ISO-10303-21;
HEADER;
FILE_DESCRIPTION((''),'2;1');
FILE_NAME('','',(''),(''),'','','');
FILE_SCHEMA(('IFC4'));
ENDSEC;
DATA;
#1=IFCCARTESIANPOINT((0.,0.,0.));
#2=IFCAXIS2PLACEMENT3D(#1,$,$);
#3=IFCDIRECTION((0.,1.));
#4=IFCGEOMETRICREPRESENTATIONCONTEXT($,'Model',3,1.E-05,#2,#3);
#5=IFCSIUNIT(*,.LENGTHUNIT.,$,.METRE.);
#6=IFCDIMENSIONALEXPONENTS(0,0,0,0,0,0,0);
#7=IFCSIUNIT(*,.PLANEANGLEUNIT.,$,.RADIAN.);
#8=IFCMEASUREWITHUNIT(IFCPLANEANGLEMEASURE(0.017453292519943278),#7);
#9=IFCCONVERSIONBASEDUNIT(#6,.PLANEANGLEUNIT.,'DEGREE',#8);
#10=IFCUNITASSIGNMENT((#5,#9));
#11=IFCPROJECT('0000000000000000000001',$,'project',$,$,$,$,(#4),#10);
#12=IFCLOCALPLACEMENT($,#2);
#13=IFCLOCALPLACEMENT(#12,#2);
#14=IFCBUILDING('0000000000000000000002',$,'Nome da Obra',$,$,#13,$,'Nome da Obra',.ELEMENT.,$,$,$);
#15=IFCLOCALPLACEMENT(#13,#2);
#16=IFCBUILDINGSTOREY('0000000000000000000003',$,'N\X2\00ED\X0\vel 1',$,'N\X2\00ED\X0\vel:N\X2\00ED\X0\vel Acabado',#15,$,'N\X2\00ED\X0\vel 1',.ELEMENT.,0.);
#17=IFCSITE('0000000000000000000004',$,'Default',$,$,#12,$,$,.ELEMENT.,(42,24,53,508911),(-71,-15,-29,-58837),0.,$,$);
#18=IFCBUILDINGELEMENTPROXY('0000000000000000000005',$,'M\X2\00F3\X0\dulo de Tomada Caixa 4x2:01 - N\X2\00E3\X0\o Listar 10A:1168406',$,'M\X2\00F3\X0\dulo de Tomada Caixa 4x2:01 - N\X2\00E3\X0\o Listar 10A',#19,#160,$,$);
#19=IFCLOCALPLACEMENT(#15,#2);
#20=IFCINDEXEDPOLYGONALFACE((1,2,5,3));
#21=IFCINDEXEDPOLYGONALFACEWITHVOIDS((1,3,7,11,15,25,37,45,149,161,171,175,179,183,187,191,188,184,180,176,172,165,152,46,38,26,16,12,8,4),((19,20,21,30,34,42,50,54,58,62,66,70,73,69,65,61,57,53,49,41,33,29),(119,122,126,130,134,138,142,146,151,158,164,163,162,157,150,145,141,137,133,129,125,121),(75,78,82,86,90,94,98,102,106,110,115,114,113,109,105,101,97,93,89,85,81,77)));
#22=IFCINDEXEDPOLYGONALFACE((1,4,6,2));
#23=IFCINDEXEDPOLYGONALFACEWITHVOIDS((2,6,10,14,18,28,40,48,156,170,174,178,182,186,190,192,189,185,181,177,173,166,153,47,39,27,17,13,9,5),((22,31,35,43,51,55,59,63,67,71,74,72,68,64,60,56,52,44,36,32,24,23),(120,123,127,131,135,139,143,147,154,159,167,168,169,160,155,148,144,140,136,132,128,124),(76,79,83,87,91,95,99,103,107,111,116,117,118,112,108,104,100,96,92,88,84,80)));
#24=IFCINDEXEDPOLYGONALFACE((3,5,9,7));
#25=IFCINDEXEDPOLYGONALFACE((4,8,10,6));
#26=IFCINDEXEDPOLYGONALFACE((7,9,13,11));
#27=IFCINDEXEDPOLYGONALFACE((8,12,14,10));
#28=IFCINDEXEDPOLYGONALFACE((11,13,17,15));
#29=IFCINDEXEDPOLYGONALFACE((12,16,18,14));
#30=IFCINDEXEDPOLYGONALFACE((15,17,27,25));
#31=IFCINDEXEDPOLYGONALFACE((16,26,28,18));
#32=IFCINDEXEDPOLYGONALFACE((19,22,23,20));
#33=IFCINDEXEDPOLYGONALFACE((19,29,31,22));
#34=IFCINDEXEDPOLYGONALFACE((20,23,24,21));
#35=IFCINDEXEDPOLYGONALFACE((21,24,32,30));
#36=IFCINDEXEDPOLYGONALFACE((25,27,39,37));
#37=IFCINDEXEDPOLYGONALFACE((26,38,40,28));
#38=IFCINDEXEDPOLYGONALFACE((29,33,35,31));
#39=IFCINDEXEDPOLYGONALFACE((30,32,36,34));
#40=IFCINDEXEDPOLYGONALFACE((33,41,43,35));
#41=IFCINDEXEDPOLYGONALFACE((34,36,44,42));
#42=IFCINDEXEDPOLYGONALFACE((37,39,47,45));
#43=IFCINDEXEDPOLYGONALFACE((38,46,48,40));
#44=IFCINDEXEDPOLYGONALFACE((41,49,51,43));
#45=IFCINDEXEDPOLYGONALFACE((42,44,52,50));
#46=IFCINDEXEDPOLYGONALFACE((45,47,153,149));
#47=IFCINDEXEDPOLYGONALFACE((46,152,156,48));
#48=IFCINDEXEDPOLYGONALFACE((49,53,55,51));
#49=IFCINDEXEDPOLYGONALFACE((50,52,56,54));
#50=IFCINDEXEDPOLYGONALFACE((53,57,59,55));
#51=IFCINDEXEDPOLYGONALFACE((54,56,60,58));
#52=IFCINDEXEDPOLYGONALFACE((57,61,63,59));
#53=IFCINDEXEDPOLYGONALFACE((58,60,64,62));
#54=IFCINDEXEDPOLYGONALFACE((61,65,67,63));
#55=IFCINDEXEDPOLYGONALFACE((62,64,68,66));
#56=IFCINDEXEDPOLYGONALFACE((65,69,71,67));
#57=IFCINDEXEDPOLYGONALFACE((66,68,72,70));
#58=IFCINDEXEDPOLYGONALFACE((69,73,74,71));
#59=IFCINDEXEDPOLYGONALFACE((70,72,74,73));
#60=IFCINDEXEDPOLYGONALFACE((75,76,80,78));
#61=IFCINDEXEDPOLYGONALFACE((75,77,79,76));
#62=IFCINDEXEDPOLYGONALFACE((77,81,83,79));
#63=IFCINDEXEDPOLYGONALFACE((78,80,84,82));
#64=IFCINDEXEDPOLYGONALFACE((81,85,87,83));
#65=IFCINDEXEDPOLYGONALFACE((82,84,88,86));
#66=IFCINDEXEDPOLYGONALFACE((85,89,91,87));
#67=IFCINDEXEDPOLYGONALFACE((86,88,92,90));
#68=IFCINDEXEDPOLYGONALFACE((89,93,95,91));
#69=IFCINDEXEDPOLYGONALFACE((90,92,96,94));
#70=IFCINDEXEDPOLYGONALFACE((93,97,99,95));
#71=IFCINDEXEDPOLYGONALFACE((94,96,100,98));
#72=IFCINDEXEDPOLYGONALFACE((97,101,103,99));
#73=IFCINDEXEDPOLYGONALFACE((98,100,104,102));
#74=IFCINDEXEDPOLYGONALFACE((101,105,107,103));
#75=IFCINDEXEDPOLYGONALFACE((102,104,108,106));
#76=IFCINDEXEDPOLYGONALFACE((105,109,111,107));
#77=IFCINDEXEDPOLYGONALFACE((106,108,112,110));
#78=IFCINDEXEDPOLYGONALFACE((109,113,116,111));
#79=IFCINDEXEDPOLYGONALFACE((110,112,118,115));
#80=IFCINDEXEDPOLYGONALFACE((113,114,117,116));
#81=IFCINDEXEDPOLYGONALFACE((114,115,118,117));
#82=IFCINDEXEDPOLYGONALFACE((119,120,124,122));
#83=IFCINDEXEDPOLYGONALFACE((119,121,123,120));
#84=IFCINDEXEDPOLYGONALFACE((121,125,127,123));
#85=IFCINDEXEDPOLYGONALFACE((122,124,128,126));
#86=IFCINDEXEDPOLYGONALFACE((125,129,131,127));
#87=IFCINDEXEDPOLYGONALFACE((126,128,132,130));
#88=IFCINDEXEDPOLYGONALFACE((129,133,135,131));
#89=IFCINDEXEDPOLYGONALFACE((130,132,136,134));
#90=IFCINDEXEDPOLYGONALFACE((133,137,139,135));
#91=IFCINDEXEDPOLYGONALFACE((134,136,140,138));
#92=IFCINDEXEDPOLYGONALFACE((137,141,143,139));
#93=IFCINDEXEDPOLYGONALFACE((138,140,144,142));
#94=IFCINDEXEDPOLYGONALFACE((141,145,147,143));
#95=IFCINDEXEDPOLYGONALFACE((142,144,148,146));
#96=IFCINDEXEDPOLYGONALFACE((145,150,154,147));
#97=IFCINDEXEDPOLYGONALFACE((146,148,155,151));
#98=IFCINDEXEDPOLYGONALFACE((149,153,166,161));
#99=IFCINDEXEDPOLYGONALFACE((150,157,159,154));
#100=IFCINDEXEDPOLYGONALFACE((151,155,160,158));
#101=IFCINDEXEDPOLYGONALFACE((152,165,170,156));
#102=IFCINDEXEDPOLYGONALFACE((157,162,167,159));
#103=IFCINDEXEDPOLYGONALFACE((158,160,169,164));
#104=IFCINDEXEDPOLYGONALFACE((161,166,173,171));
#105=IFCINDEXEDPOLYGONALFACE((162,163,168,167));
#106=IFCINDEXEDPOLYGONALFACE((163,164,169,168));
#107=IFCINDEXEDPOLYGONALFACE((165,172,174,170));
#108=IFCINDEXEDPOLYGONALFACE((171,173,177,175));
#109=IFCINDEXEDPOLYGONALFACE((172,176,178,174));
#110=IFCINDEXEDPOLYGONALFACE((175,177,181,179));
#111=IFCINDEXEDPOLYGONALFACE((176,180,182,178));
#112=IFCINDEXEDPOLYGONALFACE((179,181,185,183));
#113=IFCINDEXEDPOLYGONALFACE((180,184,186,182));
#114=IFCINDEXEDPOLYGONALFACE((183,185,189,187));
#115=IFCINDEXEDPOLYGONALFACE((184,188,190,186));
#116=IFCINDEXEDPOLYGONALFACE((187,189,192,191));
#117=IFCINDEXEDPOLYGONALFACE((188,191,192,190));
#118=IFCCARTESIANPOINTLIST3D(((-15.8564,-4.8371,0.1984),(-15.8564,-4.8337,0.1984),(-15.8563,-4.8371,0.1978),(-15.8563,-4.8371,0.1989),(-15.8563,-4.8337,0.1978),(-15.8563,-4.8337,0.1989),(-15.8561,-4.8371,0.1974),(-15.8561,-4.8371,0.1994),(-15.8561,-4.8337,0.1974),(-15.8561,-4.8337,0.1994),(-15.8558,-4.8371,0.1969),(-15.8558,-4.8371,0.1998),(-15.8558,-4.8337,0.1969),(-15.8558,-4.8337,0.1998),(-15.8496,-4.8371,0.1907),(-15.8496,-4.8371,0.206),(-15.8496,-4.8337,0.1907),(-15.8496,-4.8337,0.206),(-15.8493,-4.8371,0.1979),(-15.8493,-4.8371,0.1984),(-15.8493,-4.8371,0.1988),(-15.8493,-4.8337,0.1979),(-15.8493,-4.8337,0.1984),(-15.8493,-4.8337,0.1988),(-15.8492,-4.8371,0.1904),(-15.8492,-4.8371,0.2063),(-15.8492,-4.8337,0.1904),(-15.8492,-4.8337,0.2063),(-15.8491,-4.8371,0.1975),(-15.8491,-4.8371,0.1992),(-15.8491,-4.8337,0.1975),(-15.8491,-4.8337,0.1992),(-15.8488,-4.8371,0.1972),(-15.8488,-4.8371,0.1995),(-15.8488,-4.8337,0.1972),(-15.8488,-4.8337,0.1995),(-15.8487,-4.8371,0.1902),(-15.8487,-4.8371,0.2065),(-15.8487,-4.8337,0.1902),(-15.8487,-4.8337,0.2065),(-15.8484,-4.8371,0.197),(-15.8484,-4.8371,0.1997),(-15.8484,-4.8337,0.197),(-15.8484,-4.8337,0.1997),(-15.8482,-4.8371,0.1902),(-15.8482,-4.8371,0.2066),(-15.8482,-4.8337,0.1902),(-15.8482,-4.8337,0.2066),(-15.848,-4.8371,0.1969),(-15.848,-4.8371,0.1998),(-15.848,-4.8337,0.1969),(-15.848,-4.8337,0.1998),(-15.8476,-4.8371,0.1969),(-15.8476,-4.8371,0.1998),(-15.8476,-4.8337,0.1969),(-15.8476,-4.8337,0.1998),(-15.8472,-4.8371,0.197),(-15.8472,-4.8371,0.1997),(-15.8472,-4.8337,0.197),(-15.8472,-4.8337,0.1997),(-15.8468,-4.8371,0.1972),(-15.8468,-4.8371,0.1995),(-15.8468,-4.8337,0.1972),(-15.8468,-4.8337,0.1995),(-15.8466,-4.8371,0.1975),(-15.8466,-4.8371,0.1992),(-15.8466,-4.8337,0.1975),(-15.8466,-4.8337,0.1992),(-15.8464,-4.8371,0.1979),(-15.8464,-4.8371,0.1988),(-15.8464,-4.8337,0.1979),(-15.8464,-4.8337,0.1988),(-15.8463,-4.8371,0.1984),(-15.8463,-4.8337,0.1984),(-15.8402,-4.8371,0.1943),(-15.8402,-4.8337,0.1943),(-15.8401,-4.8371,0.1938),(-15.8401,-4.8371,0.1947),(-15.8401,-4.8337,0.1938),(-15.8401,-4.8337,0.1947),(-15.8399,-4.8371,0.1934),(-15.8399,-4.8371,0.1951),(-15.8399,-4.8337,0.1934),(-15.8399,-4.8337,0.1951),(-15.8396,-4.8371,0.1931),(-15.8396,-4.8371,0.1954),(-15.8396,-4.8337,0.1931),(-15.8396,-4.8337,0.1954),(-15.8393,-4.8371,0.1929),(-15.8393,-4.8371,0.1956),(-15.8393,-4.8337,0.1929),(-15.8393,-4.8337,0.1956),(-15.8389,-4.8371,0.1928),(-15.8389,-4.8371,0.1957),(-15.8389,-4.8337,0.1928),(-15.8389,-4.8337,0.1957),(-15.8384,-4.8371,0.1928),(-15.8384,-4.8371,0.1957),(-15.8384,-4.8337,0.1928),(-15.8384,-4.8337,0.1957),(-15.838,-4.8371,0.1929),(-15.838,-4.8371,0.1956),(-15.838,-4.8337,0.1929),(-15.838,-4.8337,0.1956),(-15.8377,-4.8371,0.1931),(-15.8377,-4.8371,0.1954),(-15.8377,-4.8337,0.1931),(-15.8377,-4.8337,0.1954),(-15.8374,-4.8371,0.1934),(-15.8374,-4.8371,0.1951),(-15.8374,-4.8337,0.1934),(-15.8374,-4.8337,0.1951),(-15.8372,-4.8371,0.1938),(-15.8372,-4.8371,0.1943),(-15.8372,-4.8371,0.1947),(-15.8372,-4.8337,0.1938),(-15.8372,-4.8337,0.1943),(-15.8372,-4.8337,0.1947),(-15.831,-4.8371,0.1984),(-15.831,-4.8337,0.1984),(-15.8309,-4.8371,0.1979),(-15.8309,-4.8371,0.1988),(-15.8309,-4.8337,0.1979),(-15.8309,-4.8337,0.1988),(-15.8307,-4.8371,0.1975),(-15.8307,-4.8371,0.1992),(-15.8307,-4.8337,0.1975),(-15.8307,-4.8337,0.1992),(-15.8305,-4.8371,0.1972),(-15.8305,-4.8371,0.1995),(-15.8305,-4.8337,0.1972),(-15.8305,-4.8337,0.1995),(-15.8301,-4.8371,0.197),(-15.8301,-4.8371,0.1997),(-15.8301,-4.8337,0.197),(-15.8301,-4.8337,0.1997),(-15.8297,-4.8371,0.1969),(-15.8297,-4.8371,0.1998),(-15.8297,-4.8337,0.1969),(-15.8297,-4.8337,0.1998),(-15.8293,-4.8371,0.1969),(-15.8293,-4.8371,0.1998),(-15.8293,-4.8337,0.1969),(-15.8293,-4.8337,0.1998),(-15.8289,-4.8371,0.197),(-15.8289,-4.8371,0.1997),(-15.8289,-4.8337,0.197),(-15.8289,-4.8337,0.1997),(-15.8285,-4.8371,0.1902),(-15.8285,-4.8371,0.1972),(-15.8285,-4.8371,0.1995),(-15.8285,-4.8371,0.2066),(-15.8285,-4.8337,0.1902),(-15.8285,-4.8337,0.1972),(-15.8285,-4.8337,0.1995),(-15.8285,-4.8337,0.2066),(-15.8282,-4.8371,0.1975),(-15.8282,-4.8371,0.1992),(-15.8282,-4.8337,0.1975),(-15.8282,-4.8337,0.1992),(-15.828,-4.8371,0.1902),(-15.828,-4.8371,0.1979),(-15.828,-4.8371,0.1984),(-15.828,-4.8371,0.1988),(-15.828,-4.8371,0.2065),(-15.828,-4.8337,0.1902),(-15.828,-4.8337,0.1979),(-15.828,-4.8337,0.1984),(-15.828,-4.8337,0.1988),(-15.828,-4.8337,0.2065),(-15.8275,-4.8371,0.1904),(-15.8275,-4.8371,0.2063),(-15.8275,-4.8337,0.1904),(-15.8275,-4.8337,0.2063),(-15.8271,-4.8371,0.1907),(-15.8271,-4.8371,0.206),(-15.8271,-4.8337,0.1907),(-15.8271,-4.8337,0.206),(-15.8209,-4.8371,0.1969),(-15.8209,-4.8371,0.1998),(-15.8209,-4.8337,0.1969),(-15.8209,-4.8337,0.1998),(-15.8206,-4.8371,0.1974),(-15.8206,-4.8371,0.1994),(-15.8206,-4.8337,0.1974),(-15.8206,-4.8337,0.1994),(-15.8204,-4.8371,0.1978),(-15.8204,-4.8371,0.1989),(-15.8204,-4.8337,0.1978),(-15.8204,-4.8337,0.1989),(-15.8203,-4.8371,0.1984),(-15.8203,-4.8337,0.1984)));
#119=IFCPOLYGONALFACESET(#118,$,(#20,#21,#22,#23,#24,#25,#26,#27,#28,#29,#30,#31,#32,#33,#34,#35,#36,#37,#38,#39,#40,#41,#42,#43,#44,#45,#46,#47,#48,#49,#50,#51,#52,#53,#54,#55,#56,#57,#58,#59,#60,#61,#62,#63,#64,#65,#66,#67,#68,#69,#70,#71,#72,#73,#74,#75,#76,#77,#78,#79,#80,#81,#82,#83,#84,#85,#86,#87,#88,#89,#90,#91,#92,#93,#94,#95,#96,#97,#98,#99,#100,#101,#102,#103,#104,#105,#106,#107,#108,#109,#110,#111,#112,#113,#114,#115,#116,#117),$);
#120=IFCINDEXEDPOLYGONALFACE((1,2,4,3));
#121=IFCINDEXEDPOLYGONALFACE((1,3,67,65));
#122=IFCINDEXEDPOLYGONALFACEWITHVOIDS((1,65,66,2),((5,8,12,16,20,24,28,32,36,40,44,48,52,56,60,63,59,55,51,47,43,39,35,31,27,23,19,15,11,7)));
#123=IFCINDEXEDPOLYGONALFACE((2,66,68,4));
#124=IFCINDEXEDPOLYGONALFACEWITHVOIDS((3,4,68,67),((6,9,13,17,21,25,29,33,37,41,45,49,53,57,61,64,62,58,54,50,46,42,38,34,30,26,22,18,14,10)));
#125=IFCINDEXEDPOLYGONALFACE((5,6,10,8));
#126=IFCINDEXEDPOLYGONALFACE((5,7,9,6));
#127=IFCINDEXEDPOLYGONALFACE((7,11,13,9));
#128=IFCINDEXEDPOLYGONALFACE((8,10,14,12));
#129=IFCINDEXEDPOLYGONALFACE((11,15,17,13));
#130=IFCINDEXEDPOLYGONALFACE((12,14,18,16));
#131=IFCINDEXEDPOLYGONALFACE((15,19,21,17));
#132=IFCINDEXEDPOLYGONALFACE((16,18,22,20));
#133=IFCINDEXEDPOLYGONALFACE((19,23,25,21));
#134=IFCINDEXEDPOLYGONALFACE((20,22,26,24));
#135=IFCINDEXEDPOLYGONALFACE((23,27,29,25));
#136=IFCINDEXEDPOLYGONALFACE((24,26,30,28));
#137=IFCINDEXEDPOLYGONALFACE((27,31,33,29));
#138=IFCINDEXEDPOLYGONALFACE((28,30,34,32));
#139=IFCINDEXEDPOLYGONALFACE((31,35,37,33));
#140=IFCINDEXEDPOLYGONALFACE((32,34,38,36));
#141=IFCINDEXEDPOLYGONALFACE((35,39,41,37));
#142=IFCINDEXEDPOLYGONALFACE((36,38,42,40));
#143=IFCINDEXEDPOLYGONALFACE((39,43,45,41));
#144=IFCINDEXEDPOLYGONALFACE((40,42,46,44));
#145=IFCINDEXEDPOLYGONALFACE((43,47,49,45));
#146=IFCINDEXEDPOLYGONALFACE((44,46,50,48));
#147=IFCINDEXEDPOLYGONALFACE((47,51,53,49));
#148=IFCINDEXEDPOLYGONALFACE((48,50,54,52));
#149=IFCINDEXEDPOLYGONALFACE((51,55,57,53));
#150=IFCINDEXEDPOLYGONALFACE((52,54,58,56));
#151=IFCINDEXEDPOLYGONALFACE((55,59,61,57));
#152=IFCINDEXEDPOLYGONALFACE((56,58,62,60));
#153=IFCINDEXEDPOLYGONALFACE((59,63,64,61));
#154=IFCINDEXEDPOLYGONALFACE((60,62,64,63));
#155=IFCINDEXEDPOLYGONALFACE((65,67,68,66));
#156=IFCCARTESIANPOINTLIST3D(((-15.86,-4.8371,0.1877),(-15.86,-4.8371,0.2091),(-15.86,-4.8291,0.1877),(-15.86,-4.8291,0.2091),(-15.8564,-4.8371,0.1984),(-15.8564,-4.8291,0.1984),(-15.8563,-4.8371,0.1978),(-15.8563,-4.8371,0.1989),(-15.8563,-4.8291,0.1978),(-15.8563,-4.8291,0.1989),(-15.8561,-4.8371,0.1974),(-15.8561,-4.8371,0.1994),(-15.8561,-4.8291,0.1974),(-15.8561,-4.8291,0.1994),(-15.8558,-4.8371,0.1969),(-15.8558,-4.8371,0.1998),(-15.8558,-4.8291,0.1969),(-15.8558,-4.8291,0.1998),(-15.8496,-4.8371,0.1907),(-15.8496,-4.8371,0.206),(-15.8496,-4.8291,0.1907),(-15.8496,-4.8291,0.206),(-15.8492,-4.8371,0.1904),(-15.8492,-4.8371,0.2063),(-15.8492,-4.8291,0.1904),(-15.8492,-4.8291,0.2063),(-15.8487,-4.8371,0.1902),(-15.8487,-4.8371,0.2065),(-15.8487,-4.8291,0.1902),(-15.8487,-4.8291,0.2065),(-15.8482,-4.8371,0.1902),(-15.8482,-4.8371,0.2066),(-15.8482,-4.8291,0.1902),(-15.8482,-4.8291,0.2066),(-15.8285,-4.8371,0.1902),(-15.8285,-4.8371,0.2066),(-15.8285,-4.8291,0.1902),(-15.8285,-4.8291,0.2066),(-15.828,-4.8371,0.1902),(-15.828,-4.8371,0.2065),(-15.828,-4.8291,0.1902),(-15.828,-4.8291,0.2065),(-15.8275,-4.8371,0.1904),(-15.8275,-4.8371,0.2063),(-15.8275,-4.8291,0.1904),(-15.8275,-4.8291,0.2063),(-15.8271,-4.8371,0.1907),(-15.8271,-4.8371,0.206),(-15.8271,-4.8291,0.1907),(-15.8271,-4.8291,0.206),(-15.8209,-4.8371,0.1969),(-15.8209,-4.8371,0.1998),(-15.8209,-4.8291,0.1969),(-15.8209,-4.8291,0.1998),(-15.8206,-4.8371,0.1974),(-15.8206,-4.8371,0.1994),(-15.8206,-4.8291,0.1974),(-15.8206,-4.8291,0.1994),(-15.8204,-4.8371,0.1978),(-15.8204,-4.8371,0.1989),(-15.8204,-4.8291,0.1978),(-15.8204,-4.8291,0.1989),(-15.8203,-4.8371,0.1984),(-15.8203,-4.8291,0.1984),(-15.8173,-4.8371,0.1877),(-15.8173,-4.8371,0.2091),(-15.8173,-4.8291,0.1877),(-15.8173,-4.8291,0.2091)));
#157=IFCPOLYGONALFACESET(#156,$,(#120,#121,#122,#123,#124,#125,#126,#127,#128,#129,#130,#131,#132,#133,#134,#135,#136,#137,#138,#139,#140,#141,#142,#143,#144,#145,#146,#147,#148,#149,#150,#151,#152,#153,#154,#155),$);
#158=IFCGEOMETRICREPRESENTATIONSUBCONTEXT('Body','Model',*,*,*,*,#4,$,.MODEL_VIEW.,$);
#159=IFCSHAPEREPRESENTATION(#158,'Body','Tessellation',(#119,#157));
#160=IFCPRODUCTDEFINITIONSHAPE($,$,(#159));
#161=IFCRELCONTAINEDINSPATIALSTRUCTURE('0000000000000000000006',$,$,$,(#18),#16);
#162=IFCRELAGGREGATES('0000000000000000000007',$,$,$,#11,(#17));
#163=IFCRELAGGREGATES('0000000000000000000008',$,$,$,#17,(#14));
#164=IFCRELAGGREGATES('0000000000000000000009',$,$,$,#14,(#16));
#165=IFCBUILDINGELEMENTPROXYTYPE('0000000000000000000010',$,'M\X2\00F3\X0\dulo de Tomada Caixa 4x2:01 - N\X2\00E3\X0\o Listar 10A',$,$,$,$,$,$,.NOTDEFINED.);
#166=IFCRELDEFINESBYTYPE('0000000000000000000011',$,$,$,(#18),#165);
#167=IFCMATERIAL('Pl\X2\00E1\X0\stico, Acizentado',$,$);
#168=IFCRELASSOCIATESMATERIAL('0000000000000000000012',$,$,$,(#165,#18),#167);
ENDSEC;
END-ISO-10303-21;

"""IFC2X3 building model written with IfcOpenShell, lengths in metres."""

from ifc_helpers import new_model, entity, si_unit, converted_unit, direction, frame, frame_2d, origin, place, context, subcontext, project, spatial, polyline, circle_curve, parameter, trimmed, segment, composite_curve, outline, extrude, source, transform, mapped, material, type_object, type_shapes, element, save


model = new_model("IFC2X3")

# Units and contexts
model_context = context("Model", 3, precision=1e-05, world=origin(), true_north=direction((0.0, 1.0)))
body_context = subcontext(model_context, "Body", "Model", "MODEL_VIEW")
ifc_project = project(units=[si_unit("LENGTHUNIT", "METRE"), converted_unit("PLANEANGLEUNIT", "DEGREE", entity("IfcPlaneAngleMeasure", 0.017453292519943278), si_unit("PLANEANGLEUNIT", "RADIAN"), dimensions=[0, 0, 0, 0, 0, 0, 0])], contexts=[model_context])

# Site, building, storey
site_placement = place(None, origin())
site = spatial("IfcSite", under=ifc_project, at=site_placement, Name="Default", CompositionType="ELEMENT", RefLatitude=(42, 24, 53, 508911), RefLongitude=(-71, -15, -29, -58837), RefElevation=0.0)
building_placement = place(site_placement, origin())
building = spatial("IfcBuilding", under=site, at=building_placement, Name="Nome da Obra", LongName="Nome da Obra", CompositionType="ELEMENT")
storey_placement = place(building_placement, origin())
storey = spatial("IfcBuildingStorey", under=building, at=storey_placement, Name="Nível 1", ObjectType="Nível:Nível Acabado", LongName="Nível 1", CompositionType="ELEMENT", Elevation=0.0)

# Building element proxy
ifc_material_1 = material(Name="Plástico, Acizentado")
building_element_proxy_type_1 = type_object("IfcBuildingElementProxyType", Name="Módulo de Tomada Caixa 4x2:01 - Não Listar 10A", PredefinedType="NOTDEFINED", material=ifc_material_1)
shared_shape_1 = source(origin(), body_context, "Body", "SweptSolid", [
    extrude(outline(composite_curve([segment(polyline([(-0.0098, -0.0082), (0.0098, -0.0082)]), True, "CONTINUOUS"), segment(trimmed(circle_curve(frame_2d((0.0098, -0.0062), x_axis=(1.0, 0.0)), 0.002), [parameter(270.0)], [parameter(315.0)], True, "PARAMETER"), True, "CONTINUOUS"), segment(polyline([(0.0112, -0.0076), (0.0174, -0.0014)]), True, "CONTINUOUS"), segment(trimmed(circle_curve(frame_2d((0.016, 0.0), x_axis=(1.0, 0.0)), 0.002), [parameter(315.0)], [parameter(45.0)], True, "PARAMETER"), True, "CONTINUOUS"), segment(polyline([(0.0174, 0.0014), (0.0112, 0.0076)]), True, "CONTINUOUS"), segment(trimmed(circle_curve(frame_2d((0.0098, 0.0062), x_axis=(1.0, 0.0)), 0.002), [parameter(45.0)], [parameter(90.0)], True, "PARAMETER"), True, "CONTINUOUS"), segment(polyline([(0.0098, 0.0082), (-0.0098, 0.0082)]), True, "CONTINUOUS"), segment(trimmed(circle_curve(frame_2d((-0.0098, 0.0062), x_axis=(1.0, 0.0)), 0.002), [parameter(90.0)], [parameter(135.0)], True, "PARAMETER"), True, "CONTINUOUS"), segment(polyline([(-0.0112, 0.0076), (-0.0174, 0.0014)]), True, "CONTINUOUS"), segment(trimmed(circle_curve(frame_2d((-0.016, 0.0), x_axis=(1.0, 0.0)), 0.002), [parameter(135.0)], [parameter(225.0)], True, "PARAMETER"), True, "CONTINUOUS"), segment(polyline([(-0.0174, -0.0014), (-0.0112, -0.0076)]), True, "CONTINUOUS"), segment(trimmed(circle_curve(frame_2d((-0.0098, -0.0062), x_axis=(1.0, 0.0)), 0.002), [parameter(225.0)], [parameter(270.0)], True, "PARAMETER"), True, "CONTINUOUS")], self_intersect=False), holes=[composite_curve([segment(trimmed(circle_curve(frame_2d((0.0089, 0.0), x_axis=(1.0, 0.0)), 0.0015), [parameter(0.0)], [parameter(180.0)], True, "PARAMETER"), False, "CONTINUOUS"), segment(trimmed(circle_curve(frame_2d((0.0089, 0.0), x_axis=(1.0, 0.0)), 0.0015), [parameter(180.0)], [parameter(0.0)], True, "PARAMETER"), False, "CONTINUOUS")], self_intersect=False), composite_curve([segment(trimmed(circle_curve(frame_2d((-0.0003, 0.0041), x_axis=(1.0, 0.0)), 0.0015), [parameter(0.0)], [parameter(180.0)], True, "PARAMETER"), False, "CONTINUOUS"), segment(trimmed(circle_curve(frame_2d((-0.0003, 0.0041), x_axis=(1.0, 0.0)), 0.0015), [parameter(180.0)], [parameter(0.0)], True, "PARAMETER"), False, "CONTINUOUS")], self_intersect=False), composite_curve([segment(trimmed(circle_curve(frame_2d((-0.0095, 0.0), x_axis=(1.0, 0.0)), 0.0015), [parameter(0.0)], [parameter(180.0)], True, "PARAMETER"), False, "CONTINUOUS"), segment(trimmed(circle_curve(frame_2d((-0.0095, 0.0), x_axis=(1.0, 0.0)), 0.0015), [parameter(180.0)], [parameter(0.0)], True, "PARAMETER"), False, "CONTINUOUS")], self_intersect=False)]), frame((0.0003, 0.0, 0.125), z_axis=(0.0, 1.0, 0.0), x_axis=(1.0, 0.0, 0.0)), (0.0, 0.0, 1.0), 0.0034),
    extrude(outline(polyline([(-0.0214, -0.0107), (0.0214, -0.0107), (0.0214, 0.0107), (-0.0214, 0.0107), (-0.0214, -0.0107)]), holes=[composite_curve([segment(polyline([(0.0101, -0.0082), (-0.0095, -0.0082)]), True, "CONTINUOUS"), segment(trimmed(circle_curve(frame_2d((-0.0095, -0.0062), x_axis=(1.0, 0.0)), 0.002), [parameter(225.0)], [parameter(270.0)], True, "PARAMETER"), False, "CONTINUOUS"), segment(polyline([(-0.0109, -0.0076), (-0.0171, -0.0014)]), True, "CONTINUOUS"), segment(trimmed(circle_curve(frame_2d((-0.0157, 0.0), x_axis=(1.0, 0.0)), 0.002), [parameter(135.0)], [parameter(225.0)], True, "PARAMETER"), False, "CONTINUOUS"), segment(polyline([(-0.0171, 0.0014), (-0.0109, 0.0076)]), True, "CONTINUOUS"), segment(trimmed(circle_curve(frame_2d((-0.0095, 0.0062), x_axis=(1.0, 0.0)), 0.002), [parameter(90.0)], [parameter(135.0)], True, "PARAMETER"), False, "CONTINUOUS"), segment(polyline([(-0.0095, 0.0082), (0.0101, 0.0082)]), True, "CONTINUOUS"), segment(trimmed(circle_curve(frame_2d((0.0101, 0.0062), x_axis=(1.0, 0.0)), 0.002), [parameter(45.0)], [parameter(90.0)], True, "PARAMETER"), False, "CONTINUOUS"), segment(polyline([(0.0115, 0.0076), (0.0177, 0.0014)]), True, "CONTINUOUS"), segment(trimmed(circle_curve(frame_2d((0.0163, 0.0), x_axis=(1.0, 0.0)), 0.002), [parameter(315.0)], [parameter(45.0)], True, "PARAMETER"), False, "CONTINUOUS"), segment(polyline([(0.0177, -0.0014), (0.0115, -0.0076)]), True, "CONTINUOUS"), segment(trimmed(circle_curve(frame_2d((0.0101, -0.0062), x_axis=(1.0, 0.0)), 0.002), [parameter(270.0)], [parameter(315.0)], True, "PARAMETER"), False, "CONTINUOUS")], self_intersect=False)]), frame((0.0, 0.0, 0.125), z_axis=(0.0, 1.0, 0.0), x_axis=(1.0, 0.0, 0.0)), (0.0, 0.0, 1.0), 0.008),
])
type_shapes(building_element_proxy_type_1, [shared_shape_1])
for number, where, name in (
    (1, (-15.8387, -4.8371, 0.0734), "Módulo de Tomada Caixa 4x2:01 - Não Listar 10A:1168406"),
):
    element("IfcBuildingElementProxy", number, at=place(storey_placement, frame(where)), inside=storey, type_object=building_element_proxy_type_1, material=ifc_material_1, Name=name, ObjectType="Módulo de Tomada Caixa 4x2:01 - Não Listar 10A", context=body_context, shape_type="MappedRepresentation", body=[
        mapped(shared_shape_1, transform((0.0, 0.0, 0.0), scale=1.0)),
    ])

save(model, "model.ifc")
